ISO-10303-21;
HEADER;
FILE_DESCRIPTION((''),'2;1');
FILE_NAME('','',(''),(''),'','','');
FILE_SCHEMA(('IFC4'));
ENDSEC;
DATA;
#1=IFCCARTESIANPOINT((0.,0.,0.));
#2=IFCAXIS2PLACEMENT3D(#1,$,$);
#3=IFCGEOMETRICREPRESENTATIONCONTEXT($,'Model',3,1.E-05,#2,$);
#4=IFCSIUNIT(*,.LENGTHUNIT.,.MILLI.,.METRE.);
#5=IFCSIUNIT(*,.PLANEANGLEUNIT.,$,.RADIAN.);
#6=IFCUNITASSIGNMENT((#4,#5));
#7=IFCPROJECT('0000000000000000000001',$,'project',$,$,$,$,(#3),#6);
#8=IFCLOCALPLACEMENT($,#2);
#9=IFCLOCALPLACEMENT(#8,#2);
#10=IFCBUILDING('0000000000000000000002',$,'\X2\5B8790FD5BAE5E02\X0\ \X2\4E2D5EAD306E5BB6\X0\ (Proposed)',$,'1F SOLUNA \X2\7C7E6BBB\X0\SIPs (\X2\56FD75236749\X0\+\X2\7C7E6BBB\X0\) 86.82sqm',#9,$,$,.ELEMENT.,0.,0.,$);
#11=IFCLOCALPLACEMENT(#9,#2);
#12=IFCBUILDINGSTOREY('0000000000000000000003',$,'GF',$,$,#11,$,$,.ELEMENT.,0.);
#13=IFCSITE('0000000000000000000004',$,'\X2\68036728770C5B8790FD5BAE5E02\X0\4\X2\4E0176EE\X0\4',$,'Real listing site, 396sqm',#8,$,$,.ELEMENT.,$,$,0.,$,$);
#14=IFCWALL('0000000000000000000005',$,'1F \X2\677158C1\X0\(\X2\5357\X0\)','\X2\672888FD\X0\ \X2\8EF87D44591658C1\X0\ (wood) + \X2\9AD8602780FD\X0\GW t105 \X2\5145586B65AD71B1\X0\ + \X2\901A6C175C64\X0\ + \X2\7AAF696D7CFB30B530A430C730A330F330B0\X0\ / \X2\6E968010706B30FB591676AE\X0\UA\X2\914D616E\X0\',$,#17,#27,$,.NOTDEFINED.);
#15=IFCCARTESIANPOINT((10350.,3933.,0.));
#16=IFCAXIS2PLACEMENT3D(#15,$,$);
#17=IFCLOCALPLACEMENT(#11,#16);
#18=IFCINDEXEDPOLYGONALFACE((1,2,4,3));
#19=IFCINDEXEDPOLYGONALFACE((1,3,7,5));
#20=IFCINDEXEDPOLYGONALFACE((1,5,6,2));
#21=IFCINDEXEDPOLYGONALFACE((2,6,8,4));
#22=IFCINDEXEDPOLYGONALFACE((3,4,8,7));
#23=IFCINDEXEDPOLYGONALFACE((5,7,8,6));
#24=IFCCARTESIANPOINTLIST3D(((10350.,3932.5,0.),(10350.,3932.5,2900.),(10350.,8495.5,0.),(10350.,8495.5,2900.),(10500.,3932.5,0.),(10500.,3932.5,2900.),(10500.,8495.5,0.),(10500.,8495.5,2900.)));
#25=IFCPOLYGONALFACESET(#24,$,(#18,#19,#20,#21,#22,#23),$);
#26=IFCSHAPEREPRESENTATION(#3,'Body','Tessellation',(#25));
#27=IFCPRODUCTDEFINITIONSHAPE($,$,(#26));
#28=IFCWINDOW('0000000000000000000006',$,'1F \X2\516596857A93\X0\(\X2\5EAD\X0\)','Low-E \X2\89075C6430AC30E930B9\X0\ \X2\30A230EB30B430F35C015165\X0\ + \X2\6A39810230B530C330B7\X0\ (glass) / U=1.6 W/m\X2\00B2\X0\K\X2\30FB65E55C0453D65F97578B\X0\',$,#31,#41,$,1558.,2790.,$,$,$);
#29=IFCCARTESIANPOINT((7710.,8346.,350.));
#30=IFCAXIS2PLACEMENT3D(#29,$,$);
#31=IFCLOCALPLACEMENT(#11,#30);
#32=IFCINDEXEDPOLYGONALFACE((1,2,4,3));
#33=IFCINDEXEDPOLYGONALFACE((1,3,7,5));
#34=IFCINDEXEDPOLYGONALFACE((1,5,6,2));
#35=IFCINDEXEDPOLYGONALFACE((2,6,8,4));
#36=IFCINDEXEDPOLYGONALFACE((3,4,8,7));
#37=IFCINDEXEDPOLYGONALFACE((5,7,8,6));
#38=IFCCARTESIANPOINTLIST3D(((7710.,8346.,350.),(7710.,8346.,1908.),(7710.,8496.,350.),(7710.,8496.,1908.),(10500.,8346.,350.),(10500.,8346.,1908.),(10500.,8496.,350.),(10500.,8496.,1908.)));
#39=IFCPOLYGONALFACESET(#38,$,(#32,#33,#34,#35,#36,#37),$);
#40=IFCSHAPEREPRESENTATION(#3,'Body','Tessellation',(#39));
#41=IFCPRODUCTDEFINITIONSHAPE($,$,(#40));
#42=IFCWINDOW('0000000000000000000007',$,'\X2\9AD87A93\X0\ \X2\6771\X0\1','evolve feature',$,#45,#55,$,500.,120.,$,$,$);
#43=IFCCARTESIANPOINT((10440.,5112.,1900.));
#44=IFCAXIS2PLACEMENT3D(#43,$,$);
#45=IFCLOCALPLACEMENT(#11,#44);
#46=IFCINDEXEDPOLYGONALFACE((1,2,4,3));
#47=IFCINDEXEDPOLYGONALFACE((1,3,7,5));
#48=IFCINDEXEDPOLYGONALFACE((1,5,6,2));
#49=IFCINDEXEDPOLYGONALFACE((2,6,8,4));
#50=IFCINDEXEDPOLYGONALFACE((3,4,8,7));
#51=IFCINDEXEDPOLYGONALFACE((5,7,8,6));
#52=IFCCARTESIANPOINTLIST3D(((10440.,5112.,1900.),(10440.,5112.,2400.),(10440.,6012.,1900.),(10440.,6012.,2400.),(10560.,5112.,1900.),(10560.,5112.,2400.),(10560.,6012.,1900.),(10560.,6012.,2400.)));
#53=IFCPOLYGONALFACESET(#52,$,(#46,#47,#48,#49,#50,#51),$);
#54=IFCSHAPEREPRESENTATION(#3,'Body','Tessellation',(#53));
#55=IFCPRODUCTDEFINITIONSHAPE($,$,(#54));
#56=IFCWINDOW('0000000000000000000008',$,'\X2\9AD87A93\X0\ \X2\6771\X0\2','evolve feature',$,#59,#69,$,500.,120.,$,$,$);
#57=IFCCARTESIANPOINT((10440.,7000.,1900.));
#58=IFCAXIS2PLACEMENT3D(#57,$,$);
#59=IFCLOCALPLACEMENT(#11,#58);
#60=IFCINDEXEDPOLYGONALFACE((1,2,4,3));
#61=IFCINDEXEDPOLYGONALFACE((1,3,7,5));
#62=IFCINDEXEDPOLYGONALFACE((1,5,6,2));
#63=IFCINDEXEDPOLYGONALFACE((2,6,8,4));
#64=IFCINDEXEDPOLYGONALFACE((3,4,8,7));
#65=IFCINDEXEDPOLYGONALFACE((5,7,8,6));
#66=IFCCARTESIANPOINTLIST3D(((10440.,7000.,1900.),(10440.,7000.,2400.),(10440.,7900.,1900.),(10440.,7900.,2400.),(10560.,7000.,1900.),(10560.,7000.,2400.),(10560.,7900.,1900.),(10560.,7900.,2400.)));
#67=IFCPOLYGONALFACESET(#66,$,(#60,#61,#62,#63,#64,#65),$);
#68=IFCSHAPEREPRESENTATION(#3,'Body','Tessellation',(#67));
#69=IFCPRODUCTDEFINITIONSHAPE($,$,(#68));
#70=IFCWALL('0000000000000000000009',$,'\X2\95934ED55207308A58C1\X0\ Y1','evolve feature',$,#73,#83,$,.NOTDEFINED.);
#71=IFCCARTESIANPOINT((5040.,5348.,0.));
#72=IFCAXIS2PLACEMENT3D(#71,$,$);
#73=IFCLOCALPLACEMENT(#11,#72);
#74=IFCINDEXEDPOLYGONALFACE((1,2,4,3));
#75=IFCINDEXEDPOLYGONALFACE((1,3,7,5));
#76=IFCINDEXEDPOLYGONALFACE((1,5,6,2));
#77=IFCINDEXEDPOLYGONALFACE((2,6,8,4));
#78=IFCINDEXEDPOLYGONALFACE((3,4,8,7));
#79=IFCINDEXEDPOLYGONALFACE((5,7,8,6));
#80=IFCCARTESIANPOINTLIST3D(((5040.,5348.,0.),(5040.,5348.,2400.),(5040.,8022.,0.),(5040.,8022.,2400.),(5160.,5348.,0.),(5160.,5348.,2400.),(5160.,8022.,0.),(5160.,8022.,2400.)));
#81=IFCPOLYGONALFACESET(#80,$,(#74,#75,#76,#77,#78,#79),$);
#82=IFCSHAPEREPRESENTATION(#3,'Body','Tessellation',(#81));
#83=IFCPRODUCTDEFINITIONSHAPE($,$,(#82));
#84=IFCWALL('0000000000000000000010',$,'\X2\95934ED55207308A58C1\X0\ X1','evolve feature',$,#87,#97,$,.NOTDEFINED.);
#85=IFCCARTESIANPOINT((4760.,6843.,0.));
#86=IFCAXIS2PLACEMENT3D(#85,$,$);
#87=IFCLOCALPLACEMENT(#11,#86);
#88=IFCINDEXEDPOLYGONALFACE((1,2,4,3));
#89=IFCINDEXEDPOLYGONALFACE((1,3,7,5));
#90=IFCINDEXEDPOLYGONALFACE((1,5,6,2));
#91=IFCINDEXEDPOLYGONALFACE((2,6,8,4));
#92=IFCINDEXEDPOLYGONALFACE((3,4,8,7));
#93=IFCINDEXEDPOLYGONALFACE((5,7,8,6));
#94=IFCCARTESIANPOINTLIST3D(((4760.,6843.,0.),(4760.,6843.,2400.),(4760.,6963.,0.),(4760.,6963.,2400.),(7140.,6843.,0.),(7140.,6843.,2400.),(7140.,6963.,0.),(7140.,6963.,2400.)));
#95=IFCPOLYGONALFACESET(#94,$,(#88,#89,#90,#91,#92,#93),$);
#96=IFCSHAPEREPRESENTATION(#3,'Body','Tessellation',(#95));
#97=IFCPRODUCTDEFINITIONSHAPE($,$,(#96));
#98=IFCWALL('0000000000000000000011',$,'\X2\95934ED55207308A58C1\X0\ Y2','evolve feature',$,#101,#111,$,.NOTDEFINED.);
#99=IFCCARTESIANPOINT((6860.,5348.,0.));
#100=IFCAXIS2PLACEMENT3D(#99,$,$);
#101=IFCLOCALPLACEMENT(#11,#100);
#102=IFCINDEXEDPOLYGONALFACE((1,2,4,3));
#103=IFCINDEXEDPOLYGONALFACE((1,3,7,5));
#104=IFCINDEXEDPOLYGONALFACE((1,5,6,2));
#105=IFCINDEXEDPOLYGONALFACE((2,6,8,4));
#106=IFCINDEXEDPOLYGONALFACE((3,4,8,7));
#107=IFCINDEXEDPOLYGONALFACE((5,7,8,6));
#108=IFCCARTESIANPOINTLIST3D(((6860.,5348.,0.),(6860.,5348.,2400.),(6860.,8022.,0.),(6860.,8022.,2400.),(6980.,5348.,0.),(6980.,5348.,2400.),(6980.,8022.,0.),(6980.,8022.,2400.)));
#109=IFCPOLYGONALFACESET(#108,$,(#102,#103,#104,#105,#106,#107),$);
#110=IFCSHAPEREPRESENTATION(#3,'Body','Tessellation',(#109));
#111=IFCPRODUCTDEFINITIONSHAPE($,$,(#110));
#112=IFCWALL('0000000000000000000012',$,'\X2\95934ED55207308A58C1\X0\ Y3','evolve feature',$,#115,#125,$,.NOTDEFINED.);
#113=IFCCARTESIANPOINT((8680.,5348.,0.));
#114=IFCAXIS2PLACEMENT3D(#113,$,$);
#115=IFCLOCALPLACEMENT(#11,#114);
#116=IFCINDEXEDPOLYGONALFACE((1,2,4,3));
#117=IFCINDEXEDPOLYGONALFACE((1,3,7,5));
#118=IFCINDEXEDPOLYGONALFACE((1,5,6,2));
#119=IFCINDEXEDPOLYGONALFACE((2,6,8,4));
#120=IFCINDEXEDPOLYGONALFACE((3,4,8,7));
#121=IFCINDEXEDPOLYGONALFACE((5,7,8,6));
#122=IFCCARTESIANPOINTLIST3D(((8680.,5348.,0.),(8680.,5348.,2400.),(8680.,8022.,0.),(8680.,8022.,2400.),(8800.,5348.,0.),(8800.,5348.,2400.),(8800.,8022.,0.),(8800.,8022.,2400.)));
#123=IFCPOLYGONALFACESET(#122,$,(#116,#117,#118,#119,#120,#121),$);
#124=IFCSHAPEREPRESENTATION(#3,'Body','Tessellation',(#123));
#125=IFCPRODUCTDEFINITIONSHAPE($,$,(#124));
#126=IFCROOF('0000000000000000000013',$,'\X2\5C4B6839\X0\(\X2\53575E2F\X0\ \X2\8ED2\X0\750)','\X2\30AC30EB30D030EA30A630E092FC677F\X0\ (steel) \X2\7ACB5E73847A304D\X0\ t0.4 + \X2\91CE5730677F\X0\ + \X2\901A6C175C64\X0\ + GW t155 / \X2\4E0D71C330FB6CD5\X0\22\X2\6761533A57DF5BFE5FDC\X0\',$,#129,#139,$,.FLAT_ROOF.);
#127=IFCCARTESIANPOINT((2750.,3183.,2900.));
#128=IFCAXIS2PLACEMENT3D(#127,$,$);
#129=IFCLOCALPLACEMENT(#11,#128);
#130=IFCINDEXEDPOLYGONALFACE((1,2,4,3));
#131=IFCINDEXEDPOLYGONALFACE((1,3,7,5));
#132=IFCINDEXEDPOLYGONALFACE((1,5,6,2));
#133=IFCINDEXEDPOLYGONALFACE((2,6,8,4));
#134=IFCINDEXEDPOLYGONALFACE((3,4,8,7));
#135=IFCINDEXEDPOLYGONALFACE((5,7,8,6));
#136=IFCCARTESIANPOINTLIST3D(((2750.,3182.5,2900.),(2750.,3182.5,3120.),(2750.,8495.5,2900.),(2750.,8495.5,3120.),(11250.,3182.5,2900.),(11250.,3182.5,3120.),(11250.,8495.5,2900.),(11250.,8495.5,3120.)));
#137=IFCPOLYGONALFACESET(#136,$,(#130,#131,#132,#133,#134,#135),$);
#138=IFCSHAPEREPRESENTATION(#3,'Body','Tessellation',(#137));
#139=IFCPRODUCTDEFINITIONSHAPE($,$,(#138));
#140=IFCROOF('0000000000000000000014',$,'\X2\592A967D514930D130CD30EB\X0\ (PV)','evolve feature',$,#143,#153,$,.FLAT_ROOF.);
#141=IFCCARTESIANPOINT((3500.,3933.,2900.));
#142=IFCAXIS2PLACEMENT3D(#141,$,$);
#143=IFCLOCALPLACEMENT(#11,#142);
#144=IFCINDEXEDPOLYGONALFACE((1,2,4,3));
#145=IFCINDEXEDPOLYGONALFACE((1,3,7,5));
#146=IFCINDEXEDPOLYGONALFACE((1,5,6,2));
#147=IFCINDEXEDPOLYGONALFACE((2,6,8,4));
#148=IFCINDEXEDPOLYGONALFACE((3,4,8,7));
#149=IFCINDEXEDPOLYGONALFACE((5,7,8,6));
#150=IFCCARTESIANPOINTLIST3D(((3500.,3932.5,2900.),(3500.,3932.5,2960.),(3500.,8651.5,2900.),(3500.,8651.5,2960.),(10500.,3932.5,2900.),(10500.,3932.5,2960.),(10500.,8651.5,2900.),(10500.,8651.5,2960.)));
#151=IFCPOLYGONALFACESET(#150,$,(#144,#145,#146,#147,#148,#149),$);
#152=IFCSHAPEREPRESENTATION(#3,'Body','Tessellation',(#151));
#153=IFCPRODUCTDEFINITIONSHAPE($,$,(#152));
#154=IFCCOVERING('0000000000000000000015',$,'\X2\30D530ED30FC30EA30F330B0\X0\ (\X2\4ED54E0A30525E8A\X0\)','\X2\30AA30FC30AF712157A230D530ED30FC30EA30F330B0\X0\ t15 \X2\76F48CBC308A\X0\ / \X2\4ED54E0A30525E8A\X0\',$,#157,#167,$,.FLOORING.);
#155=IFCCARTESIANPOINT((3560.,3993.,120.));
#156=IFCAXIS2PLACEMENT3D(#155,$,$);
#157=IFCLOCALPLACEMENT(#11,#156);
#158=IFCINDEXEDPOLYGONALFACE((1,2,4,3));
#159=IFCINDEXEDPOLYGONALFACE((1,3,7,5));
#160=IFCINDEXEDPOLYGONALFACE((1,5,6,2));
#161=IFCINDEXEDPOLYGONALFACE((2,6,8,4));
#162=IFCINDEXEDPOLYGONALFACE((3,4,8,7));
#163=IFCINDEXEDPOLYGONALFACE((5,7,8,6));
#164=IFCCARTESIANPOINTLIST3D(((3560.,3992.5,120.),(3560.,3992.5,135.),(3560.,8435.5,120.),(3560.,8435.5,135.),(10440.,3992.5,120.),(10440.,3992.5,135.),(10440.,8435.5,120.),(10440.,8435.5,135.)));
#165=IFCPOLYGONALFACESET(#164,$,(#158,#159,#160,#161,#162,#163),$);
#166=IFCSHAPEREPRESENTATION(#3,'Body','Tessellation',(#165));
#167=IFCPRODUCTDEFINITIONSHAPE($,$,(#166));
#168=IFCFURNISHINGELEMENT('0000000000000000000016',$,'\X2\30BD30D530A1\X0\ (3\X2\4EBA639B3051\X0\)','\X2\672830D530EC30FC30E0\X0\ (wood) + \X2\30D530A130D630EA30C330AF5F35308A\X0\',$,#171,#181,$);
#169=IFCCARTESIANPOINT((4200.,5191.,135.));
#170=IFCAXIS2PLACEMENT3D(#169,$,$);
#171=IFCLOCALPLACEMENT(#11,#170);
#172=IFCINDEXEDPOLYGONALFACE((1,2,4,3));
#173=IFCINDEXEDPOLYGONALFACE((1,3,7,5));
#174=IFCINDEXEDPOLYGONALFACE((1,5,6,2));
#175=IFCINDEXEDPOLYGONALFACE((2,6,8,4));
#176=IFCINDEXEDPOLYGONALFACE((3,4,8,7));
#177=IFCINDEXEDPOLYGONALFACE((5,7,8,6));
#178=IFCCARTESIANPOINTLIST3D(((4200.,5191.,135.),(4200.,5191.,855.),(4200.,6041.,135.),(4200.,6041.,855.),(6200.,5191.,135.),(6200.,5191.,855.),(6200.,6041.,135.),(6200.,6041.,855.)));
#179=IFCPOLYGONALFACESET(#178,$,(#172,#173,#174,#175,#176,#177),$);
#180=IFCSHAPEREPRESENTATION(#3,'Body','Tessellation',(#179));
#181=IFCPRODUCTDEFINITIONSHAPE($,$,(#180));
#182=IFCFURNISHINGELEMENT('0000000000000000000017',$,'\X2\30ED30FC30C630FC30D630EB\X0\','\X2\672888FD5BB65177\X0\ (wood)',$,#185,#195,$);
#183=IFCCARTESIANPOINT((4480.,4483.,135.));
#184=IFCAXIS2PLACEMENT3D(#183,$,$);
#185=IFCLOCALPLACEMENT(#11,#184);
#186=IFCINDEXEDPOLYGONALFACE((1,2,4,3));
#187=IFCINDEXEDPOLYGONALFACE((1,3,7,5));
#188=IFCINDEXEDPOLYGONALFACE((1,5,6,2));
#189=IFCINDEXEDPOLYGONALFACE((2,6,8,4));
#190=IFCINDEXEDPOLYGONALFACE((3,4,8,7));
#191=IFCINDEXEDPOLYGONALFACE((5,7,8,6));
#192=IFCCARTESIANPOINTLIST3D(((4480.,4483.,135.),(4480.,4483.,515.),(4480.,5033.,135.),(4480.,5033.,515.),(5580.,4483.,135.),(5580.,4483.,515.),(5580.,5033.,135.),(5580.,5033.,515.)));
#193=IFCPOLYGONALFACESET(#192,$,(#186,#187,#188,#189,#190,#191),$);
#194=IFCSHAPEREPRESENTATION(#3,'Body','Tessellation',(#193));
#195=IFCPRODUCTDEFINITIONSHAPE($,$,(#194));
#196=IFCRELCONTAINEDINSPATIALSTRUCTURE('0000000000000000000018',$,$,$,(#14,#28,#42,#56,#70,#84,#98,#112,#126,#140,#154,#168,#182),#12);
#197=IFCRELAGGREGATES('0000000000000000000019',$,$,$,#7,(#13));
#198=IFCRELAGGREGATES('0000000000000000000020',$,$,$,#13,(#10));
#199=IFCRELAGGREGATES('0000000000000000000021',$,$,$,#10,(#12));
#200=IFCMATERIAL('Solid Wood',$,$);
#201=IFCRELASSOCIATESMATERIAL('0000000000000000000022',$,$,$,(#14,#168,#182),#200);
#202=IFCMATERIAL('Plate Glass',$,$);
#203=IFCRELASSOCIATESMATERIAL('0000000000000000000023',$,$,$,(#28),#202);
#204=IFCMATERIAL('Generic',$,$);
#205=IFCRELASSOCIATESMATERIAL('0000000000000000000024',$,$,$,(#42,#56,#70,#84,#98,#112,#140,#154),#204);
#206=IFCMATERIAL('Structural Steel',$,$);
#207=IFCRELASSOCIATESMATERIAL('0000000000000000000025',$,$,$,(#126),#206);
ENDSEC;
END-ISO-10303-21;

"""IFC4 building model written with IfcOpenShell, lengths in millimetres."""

from ifc_helpers import new_model, si_unit, frame, frame_2d, origin, place, context, project, spatial, rectangle, extrude, material, element, fill, save


model = new_model("IFC4")

# Units and contexts
model_context = context("Model", 3, precision=1e-05, world=origin())
ifc_project = project(units=[si_unit("LENGTHUNIT", "METRE", prefix="MILLI"), si_unit("PLANEANGLEUNIT", "RADIAN")], contexts=[model_context])

# Site, building, storey
site_placement = place(None, origin())
site = spatial("IfcSite", under=ifc_project, at=site_placement, Name="栃木県宇都宮市4丁目4", ObjectType="Real listing site, 396sqm", CompositionType="ELEMENT", RefElevation=0.0)
building_placement = place(site_placement, origin())
building = spatial("IfcBuilding", under=site, at=building_placement, Name="宇都宮市 中庭の家 (Proposed)", ObjectType="1F SOLUNA 籾殻SIPs (国産杉+籾殻) 86.82sqm", CompositionType="ELEMENT", ElevationOfRefHeight=0.0, ElevationOfTerrain=0.0)
storey_placement = place(building_placement, origin())
storey = spatial("IfcBuildingStorey", under=building, at=storey_placement, Name="GF", CompositionType="ELEMENT", Elevation=0.0)

# Shared definitions
ifc_material_1 = material(Name="Solid Wood")
ifc_material_2 = material(Name="Generic")

# Shared definitions
ifc_material_3 = material(Name="Plate Glass")

# Wall, openings, windows
wall_1_placement = place(storey_placement, frame((10350.0, 3933.0, 0.0)))
wall_1 = element("IfcWall", 1, at=wall_1_placement, inside=storey, material=ifc_material_1, Name="1F 東壁(南)", Description="木製 軸組外壁 (wood) + 高性能GW t105 充填断熱 + 通気層 + 窯業系サイディング / 準耐火・外皮UA配慮", PredefinedType="NOTDEFINED", context=model_context, shape_type="SweptSolid", body=[
    extrude(rectangle(XDim=150.0, YDim=4563.0, at=frame_2d((75.0, 2281.0))), frame((10350.0, 3933.0, 0.0)), (0.0, 0.0, 1.0), 2900.0),
])
opening_1_placement = place(storey_placement, frame((7710.0, 8346.0, 350.0)))
opening_1 = element("IfcOpeningElement", 2, at=opening_1_placement, cuts=wall_1, PredefinedType="NOTDEFINED", context=model_context, shape_type="SweptSolid", body=[
    extrude(rectangle(XDim=2790.0, YDim=150.0, at=frame_2d((1395.0, 75.0))), frame((7710.0, 8346.0, 350.0)), (0.0, 0.0, 1.0), 1558.0),
])
opening_2_placement = place(storey_placement, frame((10440.0, 5112.0, 1900.0)))
opening_2 = element("IfcOpeningElement", 3, at=opening_2_placement, cuts=wall_1, PredefinedType="NOTDEFINED", context=model_context, shape_type="SweptSolid", body=[
    extrude(rectangle(XDim=120.0, YDim=900.0, at=frame_2d((60.0, 450.0))), frame((10440.0, 5112.0, 1900.0)), (0.0, 0.0, 1.0), 500.0),
])
opening_3_placement = place(storey_placement, frame((10440.0, 7000.0, 1900.0)))
opening_3 = element("IfcOpeningElement", 4, at=opening_3_placement, cuts=wall_1, PredefinedType="NOTDEFINED", context=model_context, shape_type="SweptSolid", body=[
    extrude(rectangle(XDim=120.0, YDim=900.0, at=frame_2d((60.0, 450.0))), frame((10440.0, 7000.0, 1900.0)), (0.0, 0.0, 1.0), 500.0),
])
window_1_placement = place(storey_placement, frame((7710.0, 8346.0, 350.0)))
window_1 = element("IfcWindow", 5, at=window_1_placement, inside=storey, material=ifc_material_3, Name="1F 入隅窓(庭)", Description="Low-E 複層ガラス アルゴン封入 + 樹脂サッシ (glass) / U=1.6 W/m²K・日射取得型", OverallHeight=1558.0, OverallWidth=2790.0, context=model_context, shape_type="SweptSolid", body=[
    extrude(rectangle(XDim=2790.0, YDim=150.0, at=frame_2d((1395.0, 75.0))), frame((7710.0, 8346.0, 350.0)), (0.0, 0.0, 1.0), 1558.0),
])
fill(opening_1, window_1)
window_2_placement = place(storey_placement, frame((10440.0, 5112.0, 1900.0)))
window_2 = element("IfcWindow", 6, at=window_2_placement, inside=storey, material=ifc_material_2, Name="高窓 東1", Description="evolve feature", OverallHeight=500.0, OverallWidth=120.0, context=model_context, shape_type="SweptSolid", body=[
    extrude(rectangle(XDim=120.0, YDim=900.0, at=frame_2d((60.0, 450.0))), frame((10440.0, 5112.0, 1900.0)), (0.0, 0.0, 1.0), 500.0),
])
fill(opening_2, window_2)
window_3_placement = place(storey_placement, frame((10440.0, 7000.0, 1900.0)))
window_3 = element("IfcWindow", 7, at=window_3_placement, inside=storey, material=ifc_material_2, Name="高窓 東2", Description="evolve feature", OverallHeight=500.0, OverallWidth=120.0, context=model_context, shape_type="SweptSolid", body=[
    extrude(rectangle(XDim=120.0, YDim=900.0, at=frame_2d((60.0, 450.0))), frame((10440.0, 7000.0, 1900.0)), (0.0, 0.0, 1.0), 500.0),
])
fill(opening_3, window_3)

# Walls
wall_2_placement = place(storey_placement, frame((5040.0, 5348.0, 0.0)))
element("IfcWall", 8, at=wall_2_placement, inside=storey, material=ifc_material_2, Name="間仕切り壁 Y1", Description="evolve feature", PredefinedType="NOTDEFINED", context=model_context, shape_type="SweptSolid", body=[
    extrude(rectangle(XDim=120.0, YDim=2674.0, at=frame_2d((60.0, 1337.0))), frame((5040.0, 5348.0, 0.0)), (0.0, 0.0, 1.0), 2400.0),
])
wall_3_placement = place(storey_placement, frame((4760.0, 6843.0, 0.0)))
element("IfcWall", 9, at=wall_3_placement, inside=storey, material=ifc_material_2, Name="間仕切り壁 X1", Description="evolve feature", PredefinedType="NOTDEFINED", context=model_context, shape_type="SweptSolid", body=[
    extrude(rectangle(XDim=2380.0, YDim=120.0, at=frame_2d((1190.0, 60.0))), frame((4760.0, 6843.0, 0.0)), (0.0, 0.0, 1.0), 2400.0),
])
wall_4_placement = place(storey_placement, frame((6860.0, 5348.0, 0.0)))
element("IfcWall", 10, at=wall_4_placement, inside=storey, material=ifc_material_2, Name="間仕切り壁 Y2", Description="evolve feature", PredefinedType="NOTDEFINED", context=model_context, shape_type="SweptSolid", body=[
    extrude(rectangle(XDim=120.0, YDim=2674.0, at=frame_2d((60.0, 1337.0))), frame((6860.0, 5348.0, 0.0)), (0.0, 0.0, 1.0), 2400.0),
])
wall_5_placement = place(storey_placement, frame((8680.0, 5348.0, 0.0)))
element("IfcWall", 11, at=wall_5_placement, inside=storey, material=ifc_material_2, Name="間仕切り壁 Y3", Description="evolve feature", PredefinedType="NOTDEFINED", context=model_context, shape_type="SweptSolid", body=[
    extrude(rectangle(XDim=120.0, YDim=2674.0, at=frame_2d((60.0, 1337.0))), frame((8680.0, 5348.0, 0.0)), (0.0, 0.0, 1.0), 2400.0),
])

# Roofs
ifc_material_4 = material(Name="Structural Steel")
roof_1_placement = place(storey_placement, frame((2750.0, 3183.0, 2900.0)))
element("IfcRoof", 12, at=roof_1_placement, inside=storey, material=ifc_material_4, Name="屋根(南帯 軒750)", Description="ガルバリウム鋼板 (steel) 立平葺き t0.4 + 野地板 + 通気層 + GW t155 / 不燃・法22条区域対応", PredefinedType="FLAT_ROOF", context=model_context, shape_type="SweptSolid", body=[
    extrude(rectangle(XDim=8500.0, YDim=5313.0, at=frame_2d((4250.0, 2656.0))), frame((2750.0, 3183.0, 2900.0)), (0.0, 0.0, 1.0), 220.0),
])
roof_2_placement = place(storey_placement, frame((3500.0, 3933.0, 2900.0)))
element("IfcRoof", 13, at=roof_2_placement, inside=storey, material=ifc_material_2, Name="太陽光パネル (PV)", Description="evolve feature", PredefinedType="FLAT_ROOF", context=model_context, shape_type="SweptSolid", body=[
    extrude(rectangle(XDim=7000.0, YDim=4719.0, at=frame_2d((3500.0, 2359.0))), frame((3500.0, 3933.0, 2900.0)), (0.0, 0.0, 1.0), 60.0),
])

# Covering
covering_placement = place(storey_placement, frame((3560.0, 3993.0, 120.0)))
element("IfcCovering", 14, at=covering_placement, inside=storey, material=ifc_material_2, Name="フローリング (仕上げ床)", Description="オーク無垢フローリング t15 直貼り / 仕上げ床", PredefinedType="FLOORING", context=model_context, shape_type="SweptSolid", body=[
    extrude(rectangle(XDim=6880.0, YDim=4443.0, at=frame_2d((3440.0, 2221.0))), frame((3560.0, 3993.0, 120.0)), (0.0, 0.0, 1.0), 15.0),
])

# Furnishing elements
furnishing_1_placement = place(storey_placement, frame((4200.0, 5191.0, 135.0)))
element("IfcFurnishingElement", 15, at=furnishing_1_placement, inside=storey, material=ifc_material_1, Name="ソファ (3人掛け)", Description="木フレーム (wood) + ファブリック張り", context=model_context, shape_type="SweptSolid", body=[
    extrude(rectangle(XDim=2000.0, YDim=850.0, at=frame_2d((1000.0, 425.0))), frame((4200.0, 5191.0, 135.0)), (0.0, 0.0, 1.0), 720.0),
])
furnishing_2_placement = place(storey_placement, frame((4480.0, 4483.0, 135.0)))
element("IfcFurnishingElement", 16, at=furnishing_2_placement, inside=storey, material=ifc_material_1, Name="ローテーブル", Description="木製家具 (wood)", context=model_context, shape_type="SweptSolid", body=[
    extrude(rectangle(XDim=1100.0, YDim=550.0, at=frame_2d((550.0, 275.0))), frame((4480.0, 4483.0, 135.0)), (0.0, 0.0, 1.0), 380.0),
])

save(model, "model.ifc")
